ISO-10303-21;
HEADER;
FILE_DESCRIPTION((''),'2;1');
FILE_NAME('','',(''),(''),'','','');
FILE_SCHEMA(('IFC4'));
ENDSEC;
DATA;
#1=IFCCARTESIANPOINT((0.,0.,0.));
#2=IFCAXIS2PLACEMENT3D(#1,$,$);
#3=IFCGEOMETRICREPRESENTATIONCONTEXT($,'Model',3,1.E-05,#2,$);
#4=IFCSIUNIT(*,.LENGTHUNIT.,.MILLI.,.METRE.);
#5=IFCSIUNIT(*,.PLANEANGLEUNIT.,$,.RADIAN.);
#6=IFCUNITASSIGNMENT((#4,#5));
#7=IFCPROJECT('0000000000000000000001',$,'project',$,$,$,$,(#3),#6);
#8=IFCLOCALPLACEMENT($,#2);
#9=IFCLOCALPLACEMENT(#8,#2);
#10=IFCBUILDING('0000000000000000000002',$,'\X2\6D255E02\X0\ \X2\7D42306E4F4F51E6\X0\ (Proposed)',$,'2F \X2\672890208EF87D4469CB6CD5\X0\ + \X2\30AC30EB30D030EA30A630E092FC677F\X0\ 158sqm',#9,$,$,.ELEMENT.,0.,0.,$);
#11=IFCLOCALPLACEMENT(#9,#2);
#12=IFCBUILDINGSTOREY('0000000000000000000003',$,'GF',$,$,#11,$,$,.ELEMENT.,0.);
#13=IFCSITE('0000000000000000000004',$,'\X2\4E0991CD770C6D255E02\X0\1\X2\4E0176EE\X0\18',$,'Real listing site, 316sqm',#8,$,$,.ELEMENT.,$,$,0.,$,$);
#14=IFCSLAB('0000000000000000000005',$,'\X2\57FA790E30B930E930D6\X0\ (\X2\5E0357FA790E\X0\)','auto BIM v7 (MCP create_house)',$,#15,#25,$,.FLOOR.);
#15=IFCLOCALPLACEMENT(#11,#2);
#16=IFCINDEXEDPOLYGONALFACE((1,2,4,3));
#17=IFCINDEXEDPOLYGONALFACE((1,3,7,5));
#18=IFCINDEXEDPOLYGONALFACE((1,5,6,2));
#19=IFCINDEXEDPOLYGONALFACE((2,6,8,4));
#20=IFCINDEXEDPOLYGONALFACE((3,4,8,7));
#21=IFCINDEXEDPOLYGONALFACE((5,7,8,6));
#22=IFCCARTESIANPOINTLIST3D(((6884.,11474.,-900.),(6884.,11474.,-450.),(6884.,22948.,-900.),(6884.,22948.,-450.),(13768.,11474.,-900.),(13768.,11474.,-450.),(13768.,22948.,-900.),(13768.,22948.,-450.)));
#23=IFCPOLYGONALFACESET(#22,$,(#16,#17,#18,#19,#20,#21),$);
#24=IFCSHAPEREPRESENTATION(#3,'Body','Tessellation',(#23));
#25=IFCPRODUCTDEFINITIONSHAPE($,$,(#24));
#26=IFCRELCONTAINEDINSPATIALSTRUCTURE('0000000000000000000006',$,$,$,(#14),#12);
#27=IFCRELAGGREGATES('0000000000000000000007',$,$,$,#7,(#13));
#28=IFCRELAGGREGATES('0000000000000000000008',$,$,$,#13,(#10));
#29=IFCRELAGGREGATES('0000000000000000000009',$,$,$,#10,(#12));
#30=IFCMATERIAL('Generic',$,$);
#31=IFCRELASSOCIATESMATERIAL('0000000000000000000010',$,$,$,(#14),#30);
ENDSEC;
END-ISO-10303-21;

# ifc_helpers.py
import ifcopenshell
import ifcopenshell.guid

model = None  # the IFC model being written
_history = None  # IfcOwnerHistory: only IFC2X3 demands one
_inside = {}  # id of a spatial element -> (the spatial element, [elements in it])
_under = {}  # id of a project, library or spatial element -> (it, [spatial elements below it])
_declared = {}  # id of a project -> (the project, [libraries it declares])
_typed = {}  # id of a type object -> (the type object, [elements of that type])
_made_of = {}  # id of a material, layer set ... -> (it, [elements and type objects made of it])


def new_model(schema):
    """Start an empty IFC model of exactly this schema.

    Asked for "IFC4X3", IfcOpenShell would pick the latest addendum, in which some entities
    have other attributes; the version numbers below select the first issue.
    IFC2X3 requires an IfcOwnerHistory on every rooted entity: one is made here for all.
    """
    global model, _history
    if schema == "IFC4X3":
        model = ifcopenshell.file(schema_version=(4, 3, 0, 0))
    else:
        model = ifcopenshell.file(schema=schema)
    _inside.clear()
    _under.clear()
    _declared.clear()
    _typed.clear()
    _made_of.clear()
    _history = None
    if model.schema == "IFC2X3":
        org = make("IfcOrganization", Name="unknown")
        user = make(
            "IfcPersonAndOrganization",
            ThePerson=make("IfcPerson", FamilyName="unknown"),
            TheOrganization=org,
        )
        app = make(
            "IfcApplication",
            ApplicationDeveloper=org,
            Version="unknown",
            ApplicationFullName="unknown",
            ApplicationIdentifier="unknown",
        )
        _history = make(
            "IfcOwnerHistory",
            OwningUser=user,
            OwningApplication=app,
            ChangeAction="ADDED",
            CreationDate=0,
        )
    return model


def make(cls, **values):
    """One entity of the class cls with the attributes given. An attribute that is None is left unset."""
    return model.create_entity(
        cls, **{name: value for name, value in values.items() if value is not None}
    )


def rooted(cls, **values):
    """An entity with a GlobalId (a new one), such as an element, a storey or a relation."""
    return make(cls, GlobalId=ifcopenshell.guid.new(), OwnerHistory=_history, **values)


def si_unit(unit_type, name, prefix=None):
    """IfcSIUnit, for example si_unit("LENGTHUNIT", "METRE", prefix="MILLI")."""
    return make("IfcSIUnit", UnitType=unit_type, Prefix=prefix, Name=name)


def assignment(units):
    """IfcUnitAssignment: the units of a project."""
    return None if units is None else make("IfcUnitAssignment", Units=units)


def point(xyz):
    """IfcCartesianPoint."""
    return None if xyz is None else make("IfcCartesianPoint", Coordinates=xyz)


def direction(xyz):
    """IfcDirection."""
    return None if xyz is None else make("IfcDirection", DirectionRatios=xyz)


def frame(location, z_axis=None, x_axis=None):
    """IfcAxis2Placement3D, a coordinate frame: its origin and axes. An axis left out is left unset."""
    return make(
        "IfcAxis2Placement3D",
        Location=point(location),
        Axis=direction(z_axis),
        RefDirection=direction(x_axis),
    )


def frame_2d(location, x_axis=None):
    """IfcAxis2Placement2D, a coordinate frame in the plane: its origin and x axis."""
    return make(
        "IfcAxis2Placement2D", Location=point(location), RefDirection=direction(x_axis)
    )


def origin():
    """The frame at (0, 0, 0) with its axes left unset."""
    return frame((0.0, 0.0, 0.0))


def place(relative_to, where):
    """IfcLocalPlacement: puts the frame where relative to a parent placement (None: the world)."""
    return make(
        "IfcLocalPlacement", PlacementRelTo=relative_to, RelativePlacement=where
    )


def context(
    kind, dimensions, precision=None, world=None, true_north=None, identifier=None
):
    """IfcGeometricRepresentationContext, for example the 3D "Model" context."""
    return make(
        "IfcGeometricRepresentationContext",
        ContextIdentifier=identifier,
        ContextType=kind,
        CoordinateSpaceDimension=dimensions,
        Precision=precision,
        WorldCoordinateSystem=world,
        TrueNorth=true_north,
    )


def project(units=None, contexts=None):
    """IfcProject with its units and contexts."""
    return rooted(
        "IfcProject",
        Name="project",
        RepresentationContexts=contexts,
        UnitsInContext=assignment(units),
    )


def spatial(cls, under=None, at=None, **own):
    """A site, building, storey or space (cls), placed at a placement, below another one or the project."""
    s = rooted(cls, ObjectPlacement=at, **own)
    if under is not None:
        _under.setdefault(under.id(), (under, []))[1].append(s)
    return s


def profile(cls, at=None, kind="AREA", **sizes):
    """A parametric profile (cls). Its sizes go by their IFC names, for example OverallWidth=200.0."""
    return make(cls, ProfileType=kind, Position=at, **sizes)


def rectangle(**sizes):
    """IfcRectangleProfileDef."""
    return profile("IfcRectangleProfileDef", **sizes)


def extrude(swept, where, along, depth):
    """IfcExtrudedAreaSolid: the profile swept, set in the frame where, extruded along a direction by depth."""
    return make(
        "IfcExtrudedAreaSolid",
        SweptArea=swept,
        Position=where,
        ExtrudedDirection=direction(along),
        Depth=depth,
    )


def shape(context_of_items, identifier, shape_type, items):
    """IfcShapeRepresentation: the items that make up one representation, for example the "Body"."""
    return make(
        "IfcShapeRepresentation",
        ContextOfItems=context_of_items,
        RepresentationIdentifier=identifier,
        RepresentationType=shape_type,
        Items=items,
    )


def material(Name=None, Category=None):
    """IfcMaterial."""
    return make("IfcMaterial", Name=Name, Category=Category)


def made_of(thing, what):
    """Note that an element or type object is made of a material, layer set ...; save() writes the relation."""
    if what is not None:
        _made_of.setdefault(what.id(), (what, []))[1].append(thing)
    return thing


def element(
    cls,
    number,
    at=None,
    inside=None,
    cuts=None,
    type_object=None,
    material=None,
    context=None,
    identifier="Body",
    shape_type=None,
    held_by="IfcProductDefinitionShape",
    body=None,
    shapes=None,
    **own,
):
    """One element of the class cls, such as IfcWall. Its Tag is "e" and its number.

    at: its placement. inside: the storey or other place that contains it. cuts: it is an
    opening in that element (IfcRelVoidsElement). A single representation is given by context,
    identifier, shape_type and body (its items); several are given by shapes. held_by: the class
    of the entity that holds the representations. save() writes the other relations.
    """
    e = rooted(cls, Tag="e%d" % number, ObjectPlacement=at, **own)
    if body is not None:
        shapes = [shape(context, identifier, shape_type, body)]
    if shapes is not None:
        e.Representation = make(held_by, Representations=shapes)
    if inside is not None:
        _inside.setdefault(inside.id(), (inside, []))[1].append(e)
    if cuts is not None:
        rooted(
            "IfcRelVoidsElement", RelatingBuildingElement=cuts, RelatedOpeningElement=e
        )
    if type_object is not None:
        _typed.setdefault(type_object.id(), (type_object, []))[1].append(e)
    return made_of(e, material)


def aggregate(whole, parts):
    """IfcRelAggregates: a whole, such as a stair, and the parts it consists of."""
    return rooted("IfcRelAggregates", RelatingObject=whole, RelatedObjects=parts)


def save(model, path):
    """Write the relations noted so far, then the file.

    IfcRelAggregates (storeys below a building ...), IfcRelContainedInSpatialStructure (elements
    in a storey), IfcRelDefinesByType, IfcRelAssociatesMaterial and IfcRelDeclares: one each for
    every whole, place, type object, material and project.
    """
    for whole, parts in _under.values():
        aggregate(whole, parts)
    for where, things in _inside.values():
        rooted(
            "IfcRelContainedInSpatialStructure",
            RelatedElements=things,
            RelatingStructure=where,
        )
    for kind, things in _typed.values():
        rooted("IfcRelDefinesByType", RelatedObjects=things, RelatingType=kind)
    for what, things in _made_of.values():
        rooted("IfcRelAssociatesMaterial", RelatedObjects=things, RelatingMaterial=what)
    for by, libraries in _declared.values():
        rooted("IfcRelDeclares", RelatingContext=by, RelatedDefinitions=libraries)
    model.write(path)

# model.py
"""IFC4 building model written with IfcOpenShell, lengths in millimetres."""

from ifc_helpers import new_model, si_unit, frame, frame_2d, origin, place, context, project, spatial, rectangle, extrude, material, element, save


model = new_model("IFC4")

# Units and contexts
model_context = context("Model", 3, precision=1e-05, world=origin())
ifc_project = project(units=[si_unit("LENGTHUNIT", "METRE", prefix="MILLI"), si_unit("PLANEANGLEUNIT", "RADIAN")], contexts=[model_context])

# Site, building, storey
site_placement = place(None, origin())
site = spatial("IfcSite", under=ifc_project, at=site_placement, Name="三重県津市1丁目18", ObjectType="Real listing site, 316sqm", CompositionType="ELEMENT", RefElevation=0.0)
building_placement = place(site_placement, origin())
building = spatial("IfcBuilding", under=site, at=building_placement, Name="津市 終の住処 (Proposed)", ObjectType="2F 木造軸組構法 + ガルバリウム鋼板 158sqm", CompositionType="ELEMENT", ElevationOfRefHeight=0.0, ElevationOfTerrain=0.0)
storey_placement = place(building_placement, origin())
storey = spatial("IfcBuildingStorey", under=building, at=storey_placement, Name="GF", CompositionType="ELEMENT", Elevation=0.0)

# Slab
ifc_material = material(Name="Generic")
slab_1_placement = place(storey_placement, frame((3442.0, 5737.0, -450.0)))
element("IfcSlab", 1, at=slab_1_placement, inside=storey, material=ifc_material, Name="基礎スラブ (布基礎)", Description="auto BIM v7 (MCP create_house)", PredefinedType="FLOOR", context=model_context, shape_type="SweptSolid", body=[
    extrude(rectangle(XDim=6884.0, YDim=11474.0, at=frame_2d((3442.0, 5737.0))), frame((3442.0, 5737.0, -450.0)), (0.0, 0.0, 1.0), 450.0),
])

save(model, "model.ifc")
